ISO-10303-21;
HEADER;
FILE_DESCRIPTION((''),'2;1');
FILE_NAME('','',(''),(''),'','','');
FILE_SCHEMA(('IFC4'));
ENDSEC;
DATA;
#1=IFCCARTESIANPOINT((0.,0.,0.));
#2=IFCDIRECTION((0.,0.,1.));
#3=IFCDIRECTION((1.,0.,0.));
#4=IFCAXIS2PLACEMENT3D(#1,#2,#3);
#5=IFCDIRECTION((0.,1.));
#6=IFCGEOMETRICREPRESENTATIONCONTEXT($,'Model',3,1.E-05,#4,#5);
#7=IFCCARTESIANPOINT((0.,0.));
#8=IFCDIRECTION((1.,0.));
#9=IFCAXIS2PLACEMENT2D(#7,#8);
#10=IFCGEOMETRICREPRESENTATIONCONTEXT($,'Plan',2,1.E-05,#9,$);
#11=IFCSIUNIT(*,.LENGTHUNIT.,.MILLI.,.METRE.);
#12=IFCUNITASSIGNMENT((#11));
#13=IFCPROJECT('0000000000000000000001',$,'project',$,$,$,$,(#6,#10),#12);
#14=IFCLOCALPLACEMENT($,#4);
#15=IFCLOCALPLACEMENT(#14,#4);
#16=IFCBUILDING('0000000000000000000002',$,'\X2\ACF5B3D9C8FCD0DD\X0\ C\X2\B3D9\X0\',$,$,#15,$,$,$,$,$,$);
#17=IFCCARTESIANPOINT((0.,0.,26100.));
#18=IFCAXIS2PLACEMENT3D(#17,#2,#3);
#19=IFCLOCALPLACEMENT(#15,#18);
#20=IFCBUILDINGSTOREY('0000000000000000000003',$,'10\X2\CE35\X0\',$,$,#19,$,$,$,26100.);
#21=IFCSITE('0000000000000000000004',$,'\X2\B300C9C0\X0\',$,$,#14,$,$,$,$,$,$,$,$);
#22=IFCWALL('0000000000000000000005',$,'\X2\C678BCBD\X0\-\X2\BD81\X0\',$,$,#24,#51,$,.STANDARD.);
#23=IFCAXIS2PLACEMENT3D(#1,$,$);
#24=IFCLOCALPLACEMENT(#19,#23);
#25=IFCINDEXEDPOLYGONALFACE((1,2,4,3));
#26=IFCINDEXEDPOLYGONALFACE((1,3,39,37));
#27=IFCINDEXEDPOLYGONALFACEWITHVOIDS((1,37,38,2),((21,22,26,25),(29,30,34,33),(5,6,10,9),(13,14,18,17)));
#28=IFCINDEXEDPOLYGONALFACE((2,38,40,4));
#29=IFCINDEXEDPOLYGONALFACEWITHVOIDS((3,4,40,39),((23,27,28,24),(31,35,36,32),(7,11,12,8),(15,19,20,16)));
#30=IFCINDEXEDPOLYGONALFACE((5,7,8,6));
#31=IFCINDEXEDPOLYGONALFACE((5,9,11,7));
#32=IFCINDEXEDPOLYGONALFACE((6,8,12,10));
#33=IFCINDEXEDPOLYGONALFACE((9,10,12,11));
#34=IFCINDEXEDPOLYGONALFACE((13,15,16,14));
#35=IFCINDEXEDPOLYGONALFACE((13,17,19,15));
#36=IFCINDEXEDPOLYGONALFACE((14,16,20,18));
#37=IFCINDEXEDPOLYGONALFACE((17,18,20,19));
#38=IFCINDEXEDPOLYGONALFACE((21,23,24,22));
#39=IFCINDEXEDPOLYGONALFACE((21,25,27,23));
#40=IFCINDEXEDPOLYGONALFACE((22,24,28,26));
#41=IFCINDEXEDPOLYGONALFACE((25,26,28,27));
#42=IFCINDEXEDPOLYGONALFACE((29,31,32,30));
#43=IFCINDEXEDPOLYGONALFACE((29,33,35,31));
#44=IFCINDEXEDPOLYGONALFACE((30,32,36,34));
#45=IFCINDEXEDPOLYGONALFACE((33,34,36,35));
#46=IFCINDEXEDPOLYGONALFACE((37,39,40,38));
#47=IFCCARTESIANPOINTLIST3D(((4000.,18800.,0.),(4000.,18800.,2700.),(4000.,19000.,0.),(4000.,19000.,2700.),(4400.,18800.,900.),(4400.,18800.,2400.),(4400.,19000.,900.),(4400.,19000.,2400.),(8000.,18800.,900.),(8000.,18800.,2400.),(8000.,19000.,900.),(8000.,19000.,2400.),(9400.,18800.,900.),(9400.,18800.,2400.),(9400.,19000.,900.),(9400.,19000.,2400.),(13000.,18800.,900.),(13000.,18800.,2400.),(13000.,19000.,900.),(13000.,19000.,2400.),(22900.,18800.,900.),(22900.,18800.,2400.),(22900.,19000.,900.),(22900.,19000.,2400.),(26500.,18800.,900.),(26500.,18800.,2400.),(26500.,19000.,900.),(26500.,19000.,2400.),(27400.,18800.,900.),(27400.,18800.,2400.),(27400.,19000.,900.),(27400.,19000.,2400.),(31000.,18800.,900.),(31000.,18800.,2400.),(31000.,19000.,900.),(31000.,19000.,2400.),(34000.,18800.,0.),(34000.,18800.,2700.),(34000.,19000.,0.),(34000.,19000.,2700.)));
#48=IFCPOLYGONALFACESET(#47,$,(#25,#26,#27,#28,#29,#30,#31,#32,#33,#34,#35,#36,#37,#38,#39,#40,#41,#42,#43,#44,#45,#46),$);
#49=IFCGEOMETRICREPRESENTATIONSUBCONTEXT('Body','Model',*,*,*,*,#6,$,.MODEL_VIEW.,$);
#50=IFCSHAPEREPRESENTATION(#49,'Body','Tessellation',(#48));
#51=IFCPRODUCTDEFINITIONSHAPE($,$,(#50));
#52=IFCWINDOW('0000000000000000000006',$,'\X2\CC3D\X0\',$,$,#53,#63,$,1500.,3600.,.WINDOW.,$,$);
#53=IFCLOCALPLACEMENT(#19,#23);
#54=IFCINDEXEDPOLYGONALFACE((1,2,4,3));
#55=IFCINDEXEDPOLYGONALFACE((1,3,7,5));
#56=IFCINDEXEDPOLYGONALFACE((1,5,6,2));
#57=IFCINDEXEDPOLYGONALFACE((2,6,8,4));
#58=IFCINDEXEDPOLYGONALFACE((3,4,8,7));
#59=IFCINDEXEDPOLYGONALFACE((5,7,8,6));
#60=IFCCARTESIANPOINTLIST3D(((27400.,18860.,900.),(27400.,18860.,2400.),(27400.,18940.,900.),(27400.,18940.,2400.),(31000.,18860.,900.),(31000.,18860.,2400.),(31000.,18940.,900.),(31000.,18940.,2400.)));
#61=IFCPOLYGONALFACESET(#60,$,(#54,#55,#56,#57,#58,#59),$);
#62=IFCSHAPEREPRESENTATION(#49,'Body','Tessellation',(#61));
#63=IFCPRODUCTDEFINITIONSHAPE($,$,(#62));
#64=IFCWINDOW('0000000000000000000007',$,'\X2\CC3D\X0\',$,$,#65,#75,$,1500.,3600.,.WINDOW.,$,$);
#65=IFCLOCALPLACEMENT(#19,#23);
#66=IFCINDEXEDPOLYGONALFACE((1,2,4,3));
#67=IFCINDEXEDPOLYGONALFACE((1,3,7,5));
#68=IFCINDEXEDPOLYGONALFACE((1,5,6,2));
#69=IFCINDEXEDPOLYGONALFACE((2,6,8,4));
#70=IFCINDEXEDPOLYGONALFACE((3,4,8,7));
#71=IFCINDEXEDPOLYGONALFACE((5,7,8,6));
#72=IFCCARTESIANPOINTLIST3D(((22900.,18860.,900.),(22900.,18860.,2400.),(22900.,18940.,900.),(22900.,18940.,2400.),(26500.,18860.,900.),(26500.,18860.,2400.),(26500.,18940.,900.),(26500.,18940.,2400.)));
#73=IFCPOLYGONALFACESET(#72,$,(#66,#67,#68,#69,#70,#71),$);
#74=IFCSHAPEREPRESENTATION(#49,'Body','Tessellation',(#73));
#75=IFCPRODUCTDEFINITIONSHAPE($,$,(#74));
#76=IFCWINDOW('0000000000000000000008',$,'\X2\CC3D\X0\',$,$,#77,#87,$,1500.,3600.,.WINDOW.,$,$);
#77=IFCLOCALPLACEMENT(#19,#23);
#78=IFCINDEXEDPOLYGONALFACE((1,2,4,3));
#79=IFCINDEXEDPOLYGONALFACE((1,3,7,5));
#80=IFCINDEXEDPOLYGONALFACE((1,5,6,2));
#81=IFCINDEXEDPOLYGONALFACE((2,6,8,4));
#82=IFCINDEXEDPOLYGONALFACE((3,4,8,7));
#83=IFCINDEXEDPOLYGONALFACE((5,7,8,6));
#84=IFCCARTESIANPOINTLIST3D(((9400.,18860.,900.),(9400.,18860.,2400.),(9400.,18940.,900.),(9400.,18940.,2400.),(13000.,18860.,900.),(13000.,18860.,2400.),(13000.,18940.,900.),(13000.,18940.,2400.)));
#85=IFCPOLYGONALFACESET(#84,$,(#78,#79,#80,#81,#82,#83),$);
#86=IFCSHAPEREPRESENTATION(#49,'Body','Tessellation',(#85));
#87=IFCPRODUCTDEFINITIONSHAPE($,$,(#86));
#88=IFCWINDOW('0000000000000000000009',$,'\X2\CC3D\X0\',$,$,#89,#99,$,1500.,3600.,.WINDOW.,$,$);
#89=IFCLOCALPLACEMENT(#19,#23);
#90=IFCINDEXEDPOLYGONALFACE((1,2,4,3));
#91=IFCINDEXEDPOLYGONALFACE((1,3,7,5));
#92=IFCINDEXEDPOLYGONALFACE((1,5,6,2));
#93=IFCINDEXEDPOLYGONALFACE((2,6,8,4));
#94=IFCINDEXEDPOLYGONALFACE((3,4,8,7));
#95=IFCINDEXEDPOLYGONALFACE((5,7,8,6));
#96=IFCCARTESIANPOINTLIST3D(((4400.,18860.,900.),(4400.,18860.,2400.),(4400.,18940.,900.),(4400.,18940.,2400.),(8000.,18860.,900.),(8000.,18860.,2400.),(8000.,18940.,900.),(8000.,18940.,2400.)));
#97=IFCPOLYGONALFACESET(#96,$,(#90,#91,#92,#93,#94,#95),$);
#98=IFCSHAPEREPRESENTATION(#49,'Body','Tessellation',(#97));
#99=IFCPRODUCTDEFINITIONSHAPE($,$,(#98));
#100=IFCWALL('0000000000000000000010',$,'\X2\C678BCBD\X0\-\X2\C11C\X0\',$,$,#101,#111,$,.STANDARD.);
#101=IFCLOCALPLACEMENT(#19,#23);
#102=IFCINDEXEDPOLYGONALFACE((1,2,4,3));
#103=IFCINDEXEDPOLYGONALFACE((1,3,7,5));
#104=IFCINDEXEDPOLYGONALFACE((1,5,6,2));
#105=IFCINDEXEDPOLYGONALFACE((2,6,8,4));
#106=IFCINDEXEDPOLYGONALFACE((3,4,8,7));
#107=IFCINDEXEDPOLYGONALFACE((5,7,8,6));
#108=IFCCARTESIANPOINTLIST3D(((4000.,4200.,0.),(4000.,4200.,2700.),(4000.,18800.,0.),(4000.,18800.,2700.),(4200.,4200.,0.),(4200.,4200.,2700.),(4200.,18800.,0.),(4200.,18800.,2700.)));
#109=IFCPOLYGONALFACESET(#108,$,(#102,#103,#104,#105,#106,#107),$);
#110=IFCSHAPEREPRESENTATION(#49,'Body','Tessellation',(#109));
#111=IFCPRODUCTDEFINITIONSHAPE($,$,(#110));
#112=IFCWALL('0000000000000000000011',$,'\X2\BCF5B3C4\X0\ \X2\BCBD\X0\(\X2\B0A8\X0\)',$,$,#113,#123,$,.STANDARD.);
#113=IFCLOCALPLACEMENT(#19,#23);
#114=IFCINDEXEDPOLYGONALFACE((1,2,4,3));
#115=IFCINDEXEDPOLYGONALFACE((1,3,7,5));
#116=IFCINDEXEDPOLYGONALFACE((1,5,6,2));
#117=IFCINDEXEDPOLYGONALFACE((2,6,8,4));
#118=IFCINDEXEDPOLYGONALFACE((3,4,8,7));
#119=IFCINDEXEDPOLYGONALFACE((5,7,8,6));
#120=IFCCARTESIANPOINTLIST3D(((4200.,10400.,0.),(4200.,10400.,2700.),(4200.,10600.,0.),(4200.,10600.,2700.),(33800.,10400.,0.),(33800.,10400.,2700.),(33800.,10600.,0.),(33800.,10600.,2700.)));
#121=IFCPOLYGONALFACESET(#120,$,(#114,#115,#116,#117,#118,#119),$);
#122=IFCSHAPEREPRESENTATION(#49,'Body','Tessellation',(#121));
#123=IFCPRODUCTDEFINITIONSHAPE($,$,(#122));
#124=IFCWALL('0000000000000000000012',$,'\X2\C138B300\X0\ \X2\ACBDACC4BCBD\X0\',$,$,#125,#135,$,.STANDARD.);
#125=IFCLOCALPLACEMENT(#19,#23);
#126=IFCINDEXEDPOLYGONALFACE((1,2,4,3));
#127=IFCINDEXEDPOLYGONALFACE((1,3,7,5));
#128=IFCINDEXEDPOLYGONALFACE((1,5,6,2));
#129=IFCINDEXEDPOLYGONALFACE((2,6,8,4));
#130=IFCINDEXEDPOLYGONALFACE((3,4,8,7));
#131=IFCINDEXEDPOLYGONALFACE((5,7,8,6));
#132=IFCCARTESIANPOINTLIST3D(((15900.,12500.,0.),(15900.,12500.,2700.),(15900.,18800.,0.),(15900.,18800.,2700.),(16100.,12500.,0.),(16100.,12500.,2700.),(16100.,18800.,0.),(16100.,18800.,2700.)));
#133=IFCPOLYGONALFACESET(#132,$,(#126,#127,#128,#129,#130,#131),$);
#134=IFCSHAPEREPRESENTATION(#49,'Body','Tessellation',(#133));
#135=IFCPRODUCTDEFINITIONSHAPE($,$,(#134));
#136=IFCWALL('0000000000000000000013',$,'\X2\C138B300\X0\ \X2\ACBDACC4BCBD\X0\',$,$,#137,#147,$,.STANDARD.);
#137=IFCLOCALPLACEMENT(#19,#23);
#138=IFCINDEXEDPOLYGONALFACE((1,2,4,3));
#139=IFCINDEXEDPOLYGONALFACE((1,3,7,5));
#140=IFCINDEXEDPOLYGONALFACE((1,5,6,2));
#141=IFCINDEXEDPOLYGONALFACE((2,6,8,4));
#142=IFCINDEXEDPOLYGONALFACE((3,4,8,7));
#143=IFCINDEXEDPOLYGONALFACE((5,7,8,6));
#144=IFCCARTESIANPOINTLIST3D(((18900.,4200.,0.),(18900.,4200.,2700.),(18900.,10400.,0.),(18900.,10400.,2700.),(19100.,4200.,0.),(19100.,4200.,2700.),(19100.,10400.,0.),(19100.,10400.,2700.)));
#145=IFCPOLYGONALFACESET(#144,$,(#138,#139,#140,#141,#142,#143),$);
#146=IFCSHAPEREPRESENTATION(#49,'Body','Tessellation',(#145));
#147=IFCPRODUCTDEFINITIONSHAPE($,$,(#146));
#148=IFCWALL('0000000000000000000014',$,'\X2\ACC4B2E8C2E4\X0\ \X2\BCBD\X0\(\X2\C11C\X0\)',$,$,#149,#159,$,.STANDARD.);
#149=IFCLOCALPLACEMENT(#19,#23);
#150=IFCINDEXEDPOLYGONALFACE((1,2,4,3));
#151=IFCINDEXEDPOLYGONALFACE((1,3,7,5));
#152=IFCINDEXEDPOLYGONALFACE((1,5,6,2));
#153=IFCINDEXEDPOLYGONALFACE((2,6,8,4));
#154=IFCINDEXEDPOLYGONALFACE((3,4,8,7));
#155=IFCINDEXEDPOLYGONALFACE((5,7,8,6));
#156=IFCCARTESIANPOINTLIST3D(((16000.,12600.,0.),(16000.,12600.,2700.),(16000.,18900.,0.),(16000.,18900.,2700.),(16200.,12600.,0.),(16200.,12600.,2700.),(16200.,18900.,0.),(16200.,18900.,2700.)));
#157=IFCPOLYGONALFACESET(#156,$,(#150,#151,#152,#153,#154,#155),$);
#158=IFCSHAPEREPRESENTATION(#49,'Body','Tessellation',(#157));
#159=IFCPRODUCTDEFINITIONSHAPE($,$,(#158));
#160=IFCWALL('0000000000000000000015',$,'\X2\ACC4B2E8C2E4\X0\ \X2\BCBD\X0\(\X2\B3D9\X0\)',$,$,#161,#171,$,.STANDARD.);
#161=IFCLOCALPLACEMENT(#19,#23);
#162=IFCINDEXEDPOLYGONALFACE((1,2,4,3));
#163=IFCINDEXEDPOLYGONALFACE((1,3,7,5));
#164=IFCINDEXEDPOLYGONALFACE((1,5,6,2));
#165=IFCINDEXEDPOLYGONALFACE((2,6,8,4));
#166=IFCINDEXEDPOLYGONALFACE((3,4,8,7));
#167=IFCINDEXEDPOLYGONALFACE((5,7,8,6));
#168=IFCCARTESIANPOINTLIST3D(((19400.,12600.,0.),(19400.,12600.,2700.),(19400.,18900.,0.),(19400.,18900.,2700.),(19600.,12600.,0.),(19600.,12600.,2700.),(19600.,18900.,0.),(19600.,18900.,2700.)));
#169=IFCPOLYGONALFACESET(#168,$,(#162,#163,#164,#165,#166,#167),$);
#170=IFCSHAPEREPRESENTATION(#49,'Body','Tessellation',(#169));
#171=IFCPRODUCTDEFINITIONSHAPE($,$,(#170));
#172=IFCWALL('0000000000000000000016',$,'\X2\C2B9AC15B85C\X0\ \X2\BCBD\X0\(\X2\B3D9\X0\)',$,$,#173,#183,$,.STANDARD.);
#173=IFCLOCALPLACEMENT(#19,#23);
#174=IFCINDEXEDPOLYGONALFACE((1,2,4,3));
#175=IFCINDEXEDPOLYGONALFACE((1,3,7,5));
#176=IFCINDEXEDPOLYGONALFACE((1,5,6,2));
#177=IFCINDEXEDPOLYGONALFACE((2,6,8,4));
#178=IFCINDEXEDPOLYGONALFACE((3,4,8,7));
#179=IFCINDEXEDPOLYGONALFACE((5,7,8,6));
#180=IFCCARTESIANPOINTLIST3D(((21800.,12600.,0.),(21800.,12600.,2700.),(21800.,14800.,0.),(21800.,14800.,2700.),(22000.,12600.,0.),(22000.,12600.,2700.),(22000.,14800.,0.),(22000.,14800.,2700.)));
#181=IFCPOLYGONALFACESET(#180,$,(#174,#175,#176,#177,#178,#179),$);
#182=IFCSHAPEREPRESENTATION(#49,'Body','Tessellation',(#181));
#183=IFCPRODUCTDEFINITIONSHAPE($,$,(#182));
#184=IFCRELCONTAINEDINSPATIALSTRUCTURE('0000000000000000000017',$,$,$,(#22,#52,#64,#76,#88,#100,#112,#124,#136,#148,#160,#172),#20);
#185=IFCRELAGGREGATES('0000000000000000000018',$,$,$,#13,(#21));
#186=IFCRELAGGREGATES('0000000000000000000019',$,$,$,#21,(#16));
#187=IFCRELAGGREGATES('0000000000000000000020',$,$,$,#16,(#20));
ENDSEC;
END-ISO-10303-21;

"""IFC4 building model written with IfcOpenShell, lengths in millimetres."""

from ifc_helpers import new_model, si_unit, direction, frame, origin_with_axes, origin_2d_with_axis, place, context, subcontext, project, spatial, polyline, outline, extrude, element, fill, save


model = new_model("IFC4")

# Units and contexts
model_context = context("Model", 3, precision=1e-05, world=origin_with_axes(), true_north=direction((0.0, 1.0)))
plan_context = context("Plan", 2, precision=1e-05, world=origin_2d_with_axis())
body_context = subcontext(model_context, "Body", "Model", "MODEL_VIEW")
ifc_project = project(units=[si_unit("LENGTHUNIT", "METRE", prefix="MILLI")], contexts=[model_context, plan_context])

# Site, building, storey
site_placement = place(None, origin_with_axes())
site = spatial("IfcSite", under=ifc_project, at=site_placement, Name="대지")
building_placement = place(site_placement, origin_with_axes())
building = spatial("IfcBuilding", under=site, at=building_placement, Name="공동주택 C동")
storey_placement = place(building_placement, frame((0.0, 0.0, 26100.0), z_axis=(0.0, 0.0, 1.0), x_axis=(1.0, 0.0, 0.0)))
storey = spatial("IfcBuildingStorey", under=building, at=storey_placement, Name="10층", Elevation=26100.0)

# Wall, openings, windows
wall_1_placement = place(storey_placement, origin_with_axes())
wall_1 = element("IfcWall", 1, at=wall_1_placement, inside=storey, Name="외벽-북", PredefinedType="STANDARD", context=body_context, shape_type="SweptSolid", body=[
    extrude(outline(polyline([(34000.0, 18800.0), (4000.0, 18800.0), (4000.0, 19000.0), (34000.0, 19000.0), (34000.0, 18800.0)])), origin_with_axes(), (0.0, 0.0, 1.0), 2700.0),
])
opening_1_placement = place(storey_placement, origin_with_axes())
opening_1 = element("IfcOpeningElement", 2, at=opening_1_placement, cuts=wall_1, PredefinedType="OPENING", context=body_context, shape_type="SweptSolid", body=[
    extrude(outline(polyline([(31000.0, 19050.0), (27400.0, 19050.0), (27400.0, 18750.0), (31000.0, 18750.0), (31000.0, 19050.0)])), frame((0.0, 0.0, 900.0), z_axis=(0.0, 0.0, 1.0), x_axis=(1.0, 0.0, 0.0)), (0.0, 0.0, 1.0), 1500.0),
])
opening_2_placement = place(storey_placement, origin_with_axes())
opening_2 = element("IfcOpeningElement", 3, at=opening_2_placement, cuts=wall_1, PredefinedType="OPENING", context=body_context, shape_type="SweptSolid", body=[
    extrude(outline(polyline([(26500.0, 19050.0), (22900.0, 19050.0), (22900.0, 18750.0), (26500.0, 18750.0), (26500.0, 19050.0)])), frame((0.0, 0.0, 900.0), z_axis=(0.0, 0.0, 1.0), x_axis=(1.0, 0.0, 0.0)), (0.0, 0.0, 1.0), 1500.0),
])
opening_3_placement = place(storey_placement, origin_with_axes())
opening_3 = element("IfcOpeningElement", 4, at=opening_3_placement, cuts=wall_1, PredefinedType="OPENING", context=body_context, shape_type="SweptSolid", body=[
    extrude(outline(polyline([(13000.0, 19050.0), (9400.0, 19050.0), (9400.0, 18750.0), (13000.0, 18750.0), (13000.0, 19050.0)])), frame((0.0, 0.0, 900.0), z_axis=(0.0, 0.0, 1.0), x_axis=(1.0, 0.0, 0.0)), (0.0, 0.0, 1.0), 1500.0),
])
opening_4_placement = place(storey_placement, origin_with_axes())
opening_4 = element("IfcOpeningElement", 5, at=opening_4_placement, cuts=wall_1, PredefinedType="OPENING", context=body_context, shape_type="SweptSolid", body=[
    extrude(outline(polyline([(8000.0, 19050.0), (4400.0, 19050.0), (4400.0, 18750.0), (8000.0, 18750.0), (8000.0, 19050.0)])), frame((0.0, 0.0, 900.0), z_axis=(0.0, 0.0, 1.0), x_axis=(1.0, 0.0, 0.0)), (0.0, 0.0, 1.0), 1500.0),
])
window_1_placement = place(storey_placement, origin_with_axes())
window_1 = element("IfcWindow", 6, at=window_1_placement, inside=storey, Name="창", OverallHeight=1500.0, OverallWidth=3600.0, PredefinedType="WINDOW", context=body_context, shape_type="SweptSolid", body=[
    extrude(outline(polyline([(31000.0, 18940.0), (27400.0, 18940.0), (27400.0, 18860.0), (31000.0, 18860.0), (31000.0, 18940.0)])), frame((0.0, 0.0, 900.0), z_axis=(0.0, 0.0, 1.0), x_axis=(1.0, 0.0, 0.0)), (0.0, 0.0, 1.0), 1500.0),
])
fill(opening_1, window_1)
window_2_placement = place(storey_placement, origin_with_axes())
window_2 = element("IfcWindow", 7, at=window_2_placement, inside=storey, Name="창", OverallHeight=1500.0, OverallWidth=3600.0, PredefinedType="WINDOW", context=body_context, shape_type="SweptSolid", body=[
    extrude(outline(polyline([(26500.0, 18940.0), (22900.0, 18940.0), (22900.0, 18860.0), (26500.0, 18860.0), (26500.0, 18940.0)])), frame((0.0, 0.0, 900.0), z_axis=(0.0, 0.0, 1.0), x_axis=(1.0, 0.0, 0.0)), (0.0, 0.0, 1.0), 1500.0),
])
fill(opening_2, window_2)
window_3_placement = place(storey_placement, origin_with_axes())
window_3 = element("IfcWindow", 8, at=window_3_placement, inside=storey, Name="창", OverallHeight=1500.0, OverallWidth=3600.0, PredefinedType="WINDOW", context=body_context, shape_type="SweptSolid", body=[
    extrude(outline(polyline([(13000.0, 18940.0), (9400.0, 18940.0), (9400.0, 18860.0), (13000.0, 18860.0), (13000.0, 18940.0)])), frame((0.0, 0.0, 900.0), z_axis=(0.0, 0.0, 1.0), x_axis=(1.0, 0.0, 0.0)), (0.0, 0.0, 1.0), 1500.0),
])
fill(opening_3, window_3)
window_4_placement = place(storey_placement, origin_with_axes())
window_4 = element("IfcWindow", 9, at=window_4_placement, inside=storey, Name="창", OverallHeight=1500.0, OverallWidth=3600.0, PredefinedType="WINDOW", context=body_context, shape_type="SweptSolid", body=[
    extrude(outline(polyline([(8000.0, 18940.0), (4400.0, 18940.0), (4400.0, 18860.0), (8000.0, 18860.0), (8000.0, 18940.0)])), frame((0.0, 0.0, 900.0), z_axis=(0.0, 0.0, 1.0), x_axis=(1.0, 0.0, 0.0)), (0.0, 0.0, 1.0), 1500.0),
])
fill(opening_4, window_4)

# Walls
wall_2_placement = place(storey_placement, origin_with_axes())
element("IfcWall", 10, at=wall_2_placement, inside=storey, Name="외벽-서", PredefinedType="STANDARD", context=body_context, shape_type="SweptSolid", body=[
    extrude(outline(polyline([(4200.0, 18800.0), (4200.0, 4200.0), (4000.0, 4200.0), (4000.0, 18800.0), (4200.0, 18800.0)])), origin_with_axes(), (0.0, 0.0, 1.0), 2700.0),
])
wall_3_placement = place(storey_placement, origin_with_axes())
element("IfcWall", 11, at=wall_3_placement, inside=storey, Name="복도 벽(남)", PredefinedType="STANDARD", context=body_context, shape_type="SweptSolid", body=[
    extrude(outline(polyline([(4200.0, 10600.0), (33800.0, 10600.0), (33800.0, 10400.0), (4200.0, 10400.0), (4200.0, 10600.0)])), origin_with_axes(), (0.0, 0.0, 1.0), 2700.0),
])
wall_4_placement = place(storey_placement, origin_with_axes())
element("IfcWall", 12, at=wall_4_placement, inside=storey, Name="세대 경계벽", PredefinedType="STANDARD", context=body_context, shape_type="SweptSolid", body=[
    extrude(outline(polyline([(15900.0, 12500.0), (15900.0, 18800.0), (16100.0, 18800.0), (16100.0, 12500.0), (15900.0, 12500.0)])), origin_with_axes(), (0.0, 0.0, 1.0), 2700.0),
])
wall_5_placement = place(storey_placement, origin_with_axes())
element("IfcWall", 13, at=wall_5_placement, inside=storey, Name="세대 경계벽", PredefinedType="STANDARD", context=body_context, shape_type="SweptSolid", body=[
    extrude(outline(polyline([(18900.0, 4200.0), (18900.0, 10400.0), (19100.0, 10400.0), (19100.0, 4200.0), (18900.0, 4200.0)])), origin_with_axes(), (0.0, 0.0, 1.0), 2700.0),
])
wall_6_placement = place(storey_placement, origin_with_axes())
element("IfcWall", 14, at=wall_6_placement, inside=storey, Name="계단실 벽(서)", PredefinedType="STANDARD", context=body_context, shape_type="SweptSolid", body=[
    extrude(outline(polyline([(16000.0, 12600.0), (16000.0, 18900.0), (16200.0, 18900.0), (16200.0, 12600.0), (16000.0, 12600.0)])), origin_with_axes(), (0.0, 0.0, 1.0), 2700.0),
])
wall_7_placement = place(storey_placement, origin_with_axes())
element("IfcWall", 15, at=wall_7_placement, inside=storey, Name="계단실 벽(동)", PredefinedType="STANDARD", context=body_context, shape_type="SweptSolid", body=[
    extrude(outline(polyline([(19400.0, 12600.0), (19400.0, 18900.0), (19600.0, 18900.0), (19600.0, 12600.0), (19400.0, 12600.0)])), origin_with_axes(), (0.0, 0.0, 1.0), 2700.0),
])
wall_8_placement = place(storey_placement, origin_with_axes())
element("IfcWall", 16, at=wall_8_placement, inside=storey, Name="승강로 벽(동)", PredefinedType="STANDARD", context=body_context, shape_type="SweptSolid", body=[
    extrude(outline(polyline([(21800.0, 12600.0), (21800.0, 14800.0), (22000.0, 14800.0), (22000.0, 12600.0), (21800.0, 12600.0)])), origin_with_axes(), (0.0, 0.0, 1.0), 2700.0),
])

save(model, "model.ifc")
